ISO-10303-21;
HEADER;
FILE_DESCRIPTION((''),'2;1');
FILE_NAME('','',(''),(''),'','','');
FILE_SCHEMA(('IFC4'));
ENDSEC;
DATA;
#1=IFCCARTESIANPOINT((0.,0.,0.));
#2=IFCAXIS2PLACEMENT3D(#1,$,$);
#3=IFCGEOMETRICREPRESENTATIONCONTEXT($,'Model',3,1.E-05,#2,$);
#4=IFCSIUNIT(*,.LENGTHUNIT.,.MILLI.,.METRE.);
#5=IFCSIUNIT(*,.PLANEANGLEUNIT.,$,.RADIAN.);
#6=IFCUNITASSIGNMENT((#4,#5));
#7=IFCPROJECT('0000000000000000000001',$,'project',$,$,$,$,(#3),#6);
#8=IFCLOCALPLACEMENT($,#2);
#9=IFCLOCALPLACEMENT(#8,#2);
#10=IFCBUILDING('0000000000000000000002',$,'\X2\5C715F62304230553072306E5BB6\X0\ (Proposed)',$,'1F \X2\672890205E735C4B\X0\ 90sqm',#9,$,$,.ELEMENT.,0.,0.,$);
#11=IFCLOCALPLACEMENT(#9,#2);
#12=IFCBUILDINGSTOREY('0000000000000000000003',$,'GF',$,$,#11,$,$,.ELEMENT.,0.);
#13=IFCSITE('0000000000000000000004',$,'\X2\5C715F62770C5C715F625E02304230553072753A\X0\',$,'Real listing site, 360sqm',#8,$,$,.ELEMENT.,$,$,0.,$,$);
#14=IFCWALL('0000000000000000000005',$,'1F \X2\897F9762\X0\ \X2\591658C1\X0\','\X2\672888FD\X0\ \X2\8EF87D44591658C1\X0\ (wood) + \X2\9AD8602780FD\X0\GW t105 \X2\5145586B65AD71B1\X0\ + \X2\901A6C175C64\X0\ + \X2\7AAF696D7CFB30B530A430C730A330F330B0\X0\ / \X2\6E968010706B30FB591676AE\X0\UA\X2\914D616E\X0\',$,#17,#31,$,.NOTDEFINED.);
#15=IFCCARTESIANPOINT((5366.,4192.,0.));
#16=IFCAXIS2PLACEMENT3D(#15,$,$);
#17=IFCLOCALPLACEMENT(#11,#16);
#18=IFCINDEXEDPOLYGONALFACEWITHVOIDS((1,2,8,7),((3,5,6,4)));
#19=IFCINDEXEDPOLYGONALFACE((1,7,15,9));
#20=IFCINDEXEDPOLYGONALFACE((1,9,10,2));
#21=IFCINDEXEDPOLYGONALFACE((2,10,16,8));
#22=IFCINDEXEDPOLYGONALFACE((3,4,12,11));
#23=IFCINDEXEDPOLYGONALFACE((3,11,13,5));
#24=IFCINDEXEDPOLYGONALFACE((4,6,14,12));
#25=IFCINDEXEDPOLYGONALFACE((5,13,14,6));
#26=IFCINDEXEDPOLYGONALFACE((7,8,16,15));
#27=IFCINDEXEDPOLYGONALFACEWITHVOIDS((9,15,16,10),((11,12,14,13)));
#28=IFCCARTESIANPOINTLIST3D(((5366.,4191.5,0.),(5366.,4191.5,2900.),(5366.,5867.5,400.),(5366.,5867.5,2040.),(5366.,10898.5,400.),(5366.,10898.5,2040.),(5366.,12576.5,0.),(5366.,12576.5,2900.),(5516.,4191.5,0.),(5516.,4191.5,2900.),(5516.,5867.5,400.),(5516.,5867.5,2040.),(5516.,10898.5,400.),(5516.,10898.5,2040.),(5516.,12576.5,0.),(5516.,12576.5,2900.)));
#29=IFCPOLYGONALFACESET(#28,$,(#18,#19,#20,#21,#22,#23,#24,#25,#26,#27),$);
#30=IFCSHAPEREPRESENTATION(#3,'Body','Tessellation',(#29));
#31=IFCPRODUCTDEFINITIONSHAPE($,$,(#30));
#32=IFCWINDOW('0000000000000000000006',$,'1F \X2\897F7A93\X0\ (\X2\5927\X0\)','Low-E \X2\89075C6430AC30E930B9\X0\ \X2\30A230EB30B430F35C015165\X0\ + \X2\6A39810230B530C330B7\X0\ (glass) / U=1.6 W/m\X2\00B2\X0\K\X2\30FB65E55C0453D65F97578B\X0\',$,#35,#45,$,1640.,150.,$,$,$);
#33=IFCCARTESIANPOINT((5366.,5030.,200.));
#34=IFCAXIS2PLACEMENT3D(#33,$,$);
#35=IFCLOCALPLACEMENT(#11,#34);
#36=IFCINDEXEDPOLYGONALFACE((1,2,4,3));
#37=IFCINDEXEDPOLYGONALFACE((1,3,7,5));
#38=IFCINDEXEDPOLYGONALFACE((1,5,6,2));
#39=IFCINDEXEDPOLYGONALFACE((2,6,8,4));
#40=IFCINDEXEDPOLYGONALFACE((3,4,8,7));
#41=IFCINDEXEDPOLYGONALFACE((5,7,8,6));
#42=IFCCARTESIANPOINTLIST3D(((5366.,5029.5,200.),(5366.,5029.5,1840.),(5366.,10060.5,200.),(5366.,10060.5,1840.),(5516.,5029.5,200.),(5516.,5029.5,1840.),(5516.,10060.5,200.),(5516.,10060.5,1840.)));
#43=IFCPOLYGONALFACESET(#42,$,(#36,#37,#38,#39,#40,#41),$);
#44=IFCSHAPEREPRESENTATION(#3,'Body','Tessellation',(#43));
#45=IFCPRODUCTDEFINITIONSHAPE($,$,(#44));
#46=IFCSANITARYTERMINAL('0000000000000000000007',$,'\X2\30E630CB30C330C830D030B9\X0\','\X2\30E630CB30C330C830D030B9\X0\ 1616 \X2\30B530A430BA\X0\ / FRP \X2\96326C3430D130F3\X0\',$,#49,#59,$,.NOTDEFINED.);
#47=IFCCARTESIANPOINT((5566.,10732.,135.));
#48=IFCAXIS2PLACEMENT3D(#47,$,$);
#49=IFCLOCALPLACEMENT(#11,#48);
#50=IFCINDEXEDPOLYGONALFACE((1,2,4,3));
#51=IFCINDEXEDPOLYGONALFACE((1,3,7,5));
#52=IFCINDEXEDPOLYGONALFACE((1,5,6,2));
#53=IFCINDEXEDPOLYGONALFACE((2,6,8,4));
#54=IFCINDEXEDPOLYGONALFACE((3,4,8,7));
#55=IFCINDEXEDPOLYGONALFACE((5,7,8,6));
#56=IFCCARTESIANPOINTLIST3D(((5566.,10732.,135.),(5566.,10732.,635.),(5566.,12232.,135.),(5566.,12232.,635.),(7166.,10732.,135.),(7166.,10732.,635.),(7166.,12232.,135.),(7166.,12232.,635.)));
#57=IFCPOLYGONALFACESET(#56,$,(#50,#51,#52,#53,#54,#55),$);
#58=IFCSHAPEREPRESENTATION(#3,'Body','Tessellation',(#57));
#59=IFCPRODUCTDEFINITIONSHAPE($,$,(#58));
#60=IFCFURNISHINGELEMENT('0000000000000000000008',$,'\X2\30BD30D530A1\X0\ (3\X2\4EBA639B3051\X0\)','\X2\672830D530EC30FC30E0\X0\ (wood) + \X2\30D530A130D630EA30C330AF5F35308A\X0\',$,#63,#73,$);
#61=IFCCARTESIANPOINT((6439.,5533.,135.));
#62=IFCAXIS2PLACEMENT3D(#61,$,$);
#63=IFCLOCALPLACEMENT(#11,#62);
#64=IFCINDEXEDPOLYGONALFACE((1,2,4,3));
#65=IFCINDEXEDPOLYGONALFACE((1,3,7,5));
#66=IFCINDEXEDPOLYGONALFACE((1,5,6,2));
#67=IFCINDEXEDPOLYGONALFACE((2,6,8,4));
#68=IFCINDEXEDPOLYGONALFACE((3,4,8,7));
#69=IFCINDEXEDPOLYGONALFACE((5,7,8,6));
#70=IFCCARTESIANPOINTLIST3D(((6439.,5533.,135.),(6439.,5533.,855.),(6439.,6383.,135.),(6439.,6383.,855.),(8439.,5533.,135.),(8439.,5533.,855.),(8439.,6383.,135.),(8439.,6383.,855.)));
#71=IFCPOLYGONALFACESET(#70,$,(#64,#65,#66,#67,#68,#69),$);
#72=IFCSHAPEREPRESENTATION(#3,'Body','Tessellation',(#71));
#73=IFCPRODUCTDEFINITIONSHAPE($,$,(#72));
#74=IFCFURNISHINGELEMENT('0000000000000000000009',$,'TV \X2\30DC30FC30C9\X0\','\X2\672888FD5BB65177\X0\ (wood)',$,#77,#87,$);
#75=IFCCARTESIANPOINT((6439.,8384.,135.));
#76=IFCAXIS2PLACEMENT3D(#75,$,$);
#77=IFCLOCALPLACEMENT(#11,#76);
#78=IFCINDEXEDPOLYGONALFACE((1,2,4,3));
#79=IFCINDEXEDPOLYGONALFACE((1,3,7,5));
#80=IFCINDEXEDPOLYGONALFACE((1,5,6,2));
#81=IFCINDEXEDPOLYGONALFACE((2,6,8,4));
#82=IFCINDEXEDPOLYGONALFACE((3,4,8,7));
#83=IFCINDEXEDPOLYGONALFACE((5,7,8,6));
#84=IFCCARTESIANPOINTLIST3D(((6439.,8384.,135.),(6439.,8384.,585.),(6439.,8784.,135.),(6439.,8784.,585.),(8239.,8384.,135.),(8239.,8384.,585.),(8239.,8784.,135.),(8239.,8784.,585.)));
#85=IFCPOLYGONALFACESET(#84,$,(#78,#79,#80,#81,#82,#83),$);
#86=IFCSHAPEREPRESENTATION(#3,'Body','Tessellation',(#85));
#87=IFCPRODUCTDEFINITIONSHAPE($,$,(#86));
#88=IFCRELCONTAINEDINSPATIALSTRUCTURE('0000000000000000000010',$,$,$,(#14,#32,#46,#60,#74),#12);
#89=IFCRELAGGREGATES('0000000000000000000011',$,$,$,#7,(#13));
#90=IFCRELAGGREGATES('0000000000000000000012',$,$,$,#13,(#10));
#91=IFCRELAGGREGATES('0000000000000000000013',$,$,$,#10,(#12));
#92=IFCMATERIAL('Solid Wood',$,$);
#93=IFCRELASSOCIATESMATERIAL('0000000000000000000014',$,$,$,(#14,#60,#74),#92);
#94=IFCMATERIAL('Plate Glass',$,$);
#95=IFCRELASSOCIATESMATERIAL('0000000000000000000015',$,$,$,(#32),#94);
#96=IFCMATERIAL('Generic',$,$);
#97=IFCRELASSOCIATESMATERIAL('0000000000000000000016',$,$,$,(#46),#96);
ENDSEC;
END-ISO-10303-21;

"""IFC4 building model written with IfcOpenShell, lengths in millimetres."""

from ifc_helpers import new_model, si_unit, frame, frame_2d, origin, place, context, project, spatial, rectangle, extrude, material, element, fill, save


model = new_model("IFC4")

# Units and contexts
model_context = context("Model", 3, precision=1e-05, world=origin())
ifc_project = project(units=[si_unit("LENGTHUNIT", "METRE", prefix="MILLI"), si_unit("PLANEANGLEUNIT", "RADIAN")], contexts=[model_context])

# Site, building, storey
site_placement = place(None, origin())
site = spatial("IfcSite", under=ifc_project, at=site_placement, Name="山形県山形市あさひ町", ObjectType="Real listing site, 360sqm", CompositionType="ELEMENT", RefElevation=0.0)
building_placement = place(site_placement, origin())
building = spatial("IfcBuilding", under=site, at=building_placement, Name="山形あさひの家 (Proposed)", ObjectType="1F 木造平屋 90sqm", CompositionType="ELEMENT", ElevationOfRefHeight=0.0, ElevationOfTerrain=0.0)
storey_placement = place(building_placement, origin())
storey = spatial("IfcBuildingStorey", under=building, at=storey_placement, Name="GF", CompositionType="ELEMENT", Elevation=0.0)

# Shared definitions
ifc_material_1 = material(Name="Solid Wood")

# Shared definitions
ifc_material_2 = material(Name="Plate Glass")

# Wall, opening, window
wall_1_placement = place(storey_placement, frame((5366.0, 4192.0, 0.0)))
wall_1 = element("IfcWall", 1, at=wall_1_placement, inside=storey, material=ifc_material_1, Name="1F 西面 外壁", Description="木製 軸組外壁 (wood) + 高性能GW t105 充填断熱 + 通気層 + 窯業系サイディング / 準耐火・外皮UA配慮", PredefinedType="NOTDEFINED", context=model_context, shape_type="SweptSolid", body=[
    extrude(rectangle(XDim=150.0, YDim=8385.0, at=frame_2d((75.0, 4192.0))), frame((5366.0, 4192.0, 0.0)), (0.0, 0.0, 1.0), 2900.0),
])
opening_1_placement = place(storey_placement, frame((5366.0, 5030.0, 200.0)))
opening_1 = element("IfcOpeningElement", 2, at=opening_1_placement, cuts=wall_1, PredefinedType="NOTDEFINED", context=model_context, shape_type="SweptSolid", body=[
    extrude(rectangle(XDim=150.0, YDim=5031.0, at=frame_2d((75.0, 2515.0))), frame((5366.0, 5030.0, 200.0)), (0.0, 0.0, 1.0), 1640.0),
])
window_1_placement = place(storey_placement, frame((5366.0, 5030.0, 200.0)))
window_1 = element("IfcWindow", 3, at=window_1_placement, inside=storey, material=ifc_material_2, Name="1F 西窓 (大)", Description="Low-E 複層ガラス アルゴン封入 + 樹脂サッシ (glass) / U=1.6 W/m²K・日射取得型", OverallHeight=1640.0, OverallWidth=150.0, context=model_context, shape_type="SweptSolid", body=[
    extrude(rectangle(XDim=150.0, YDim=5031.0, at=frame_2d((75.0, 2515.0))), frame((5366.0, 5030.0, 200.0)), (0.0, 0.0, 1.0), 1640.0),
])
fill(opening_1, window_1)

# Shared definitions
ifc_material_3 = material(Name="Generic")

# Sanitary terminal
sanitary_terminal_placement = place(storey_placement, frame((5566.0, 10732.0, 135.0)))
element("IfcSanitaryTerminal", 4, at=sanitary_terminal_placement, inside=storey, material=ifc_material_3, Name="ユニットバス", Description="ユニットバス 1616 サイズ / FRP 防水パン", PredefinedType="NOTDEFINED", context=model_context, shape_type="SweptSolid", body=[
    extrude(rectangle(XDim=1600.0, YDim=1500.0, at=frame_2d((800.0, 750.0))), frame((5566.0, 10732.0, 135.0)), (0.0, 0.0, 1.0), 500.0),
])

# Furnishing elements
furnishing_1_placement = place(storey_placement, frame((6439.0, 5533.0, 135.0)))
element("IfcFurnishingElement", 5, at=furnishing_1_placement, inside=storey, material=ifc_material_1, Name="ソファ (3人掛け)", Description="木フレーム (wood) + ファブリック張り", context=model_context, shape_type="SweptSolid", body=[
    extrude(rectangle(XDim=2000.0, YDim=850.0, at=frame_2d((1000.0, 425.0))), frame((6439.0, 5533.0, 135.0)), (0.0, 0.0, 1.0), 720.0),
])
furnishing_2_placement = place(storey_placement, frame((6439.0, 8384.0, 135.0)))
element("IfcFurnishingElement", 6, at=furnishing_2_placement, inside=storey, material=ifc_material_1, Name="TV ボード", Description="木製家具 (wood)", context=model_context, shape_type="SweptSolid", body=[
    extrude(rectangle(XDim=1800.0, YDim=400.0, at=frame_2d((900.0, 200.0))), frame((6439.0, 8384.0, 135.0)), (0.0, 0.0, 1.0), 450.0),
])

save(model, "model.ifc")
